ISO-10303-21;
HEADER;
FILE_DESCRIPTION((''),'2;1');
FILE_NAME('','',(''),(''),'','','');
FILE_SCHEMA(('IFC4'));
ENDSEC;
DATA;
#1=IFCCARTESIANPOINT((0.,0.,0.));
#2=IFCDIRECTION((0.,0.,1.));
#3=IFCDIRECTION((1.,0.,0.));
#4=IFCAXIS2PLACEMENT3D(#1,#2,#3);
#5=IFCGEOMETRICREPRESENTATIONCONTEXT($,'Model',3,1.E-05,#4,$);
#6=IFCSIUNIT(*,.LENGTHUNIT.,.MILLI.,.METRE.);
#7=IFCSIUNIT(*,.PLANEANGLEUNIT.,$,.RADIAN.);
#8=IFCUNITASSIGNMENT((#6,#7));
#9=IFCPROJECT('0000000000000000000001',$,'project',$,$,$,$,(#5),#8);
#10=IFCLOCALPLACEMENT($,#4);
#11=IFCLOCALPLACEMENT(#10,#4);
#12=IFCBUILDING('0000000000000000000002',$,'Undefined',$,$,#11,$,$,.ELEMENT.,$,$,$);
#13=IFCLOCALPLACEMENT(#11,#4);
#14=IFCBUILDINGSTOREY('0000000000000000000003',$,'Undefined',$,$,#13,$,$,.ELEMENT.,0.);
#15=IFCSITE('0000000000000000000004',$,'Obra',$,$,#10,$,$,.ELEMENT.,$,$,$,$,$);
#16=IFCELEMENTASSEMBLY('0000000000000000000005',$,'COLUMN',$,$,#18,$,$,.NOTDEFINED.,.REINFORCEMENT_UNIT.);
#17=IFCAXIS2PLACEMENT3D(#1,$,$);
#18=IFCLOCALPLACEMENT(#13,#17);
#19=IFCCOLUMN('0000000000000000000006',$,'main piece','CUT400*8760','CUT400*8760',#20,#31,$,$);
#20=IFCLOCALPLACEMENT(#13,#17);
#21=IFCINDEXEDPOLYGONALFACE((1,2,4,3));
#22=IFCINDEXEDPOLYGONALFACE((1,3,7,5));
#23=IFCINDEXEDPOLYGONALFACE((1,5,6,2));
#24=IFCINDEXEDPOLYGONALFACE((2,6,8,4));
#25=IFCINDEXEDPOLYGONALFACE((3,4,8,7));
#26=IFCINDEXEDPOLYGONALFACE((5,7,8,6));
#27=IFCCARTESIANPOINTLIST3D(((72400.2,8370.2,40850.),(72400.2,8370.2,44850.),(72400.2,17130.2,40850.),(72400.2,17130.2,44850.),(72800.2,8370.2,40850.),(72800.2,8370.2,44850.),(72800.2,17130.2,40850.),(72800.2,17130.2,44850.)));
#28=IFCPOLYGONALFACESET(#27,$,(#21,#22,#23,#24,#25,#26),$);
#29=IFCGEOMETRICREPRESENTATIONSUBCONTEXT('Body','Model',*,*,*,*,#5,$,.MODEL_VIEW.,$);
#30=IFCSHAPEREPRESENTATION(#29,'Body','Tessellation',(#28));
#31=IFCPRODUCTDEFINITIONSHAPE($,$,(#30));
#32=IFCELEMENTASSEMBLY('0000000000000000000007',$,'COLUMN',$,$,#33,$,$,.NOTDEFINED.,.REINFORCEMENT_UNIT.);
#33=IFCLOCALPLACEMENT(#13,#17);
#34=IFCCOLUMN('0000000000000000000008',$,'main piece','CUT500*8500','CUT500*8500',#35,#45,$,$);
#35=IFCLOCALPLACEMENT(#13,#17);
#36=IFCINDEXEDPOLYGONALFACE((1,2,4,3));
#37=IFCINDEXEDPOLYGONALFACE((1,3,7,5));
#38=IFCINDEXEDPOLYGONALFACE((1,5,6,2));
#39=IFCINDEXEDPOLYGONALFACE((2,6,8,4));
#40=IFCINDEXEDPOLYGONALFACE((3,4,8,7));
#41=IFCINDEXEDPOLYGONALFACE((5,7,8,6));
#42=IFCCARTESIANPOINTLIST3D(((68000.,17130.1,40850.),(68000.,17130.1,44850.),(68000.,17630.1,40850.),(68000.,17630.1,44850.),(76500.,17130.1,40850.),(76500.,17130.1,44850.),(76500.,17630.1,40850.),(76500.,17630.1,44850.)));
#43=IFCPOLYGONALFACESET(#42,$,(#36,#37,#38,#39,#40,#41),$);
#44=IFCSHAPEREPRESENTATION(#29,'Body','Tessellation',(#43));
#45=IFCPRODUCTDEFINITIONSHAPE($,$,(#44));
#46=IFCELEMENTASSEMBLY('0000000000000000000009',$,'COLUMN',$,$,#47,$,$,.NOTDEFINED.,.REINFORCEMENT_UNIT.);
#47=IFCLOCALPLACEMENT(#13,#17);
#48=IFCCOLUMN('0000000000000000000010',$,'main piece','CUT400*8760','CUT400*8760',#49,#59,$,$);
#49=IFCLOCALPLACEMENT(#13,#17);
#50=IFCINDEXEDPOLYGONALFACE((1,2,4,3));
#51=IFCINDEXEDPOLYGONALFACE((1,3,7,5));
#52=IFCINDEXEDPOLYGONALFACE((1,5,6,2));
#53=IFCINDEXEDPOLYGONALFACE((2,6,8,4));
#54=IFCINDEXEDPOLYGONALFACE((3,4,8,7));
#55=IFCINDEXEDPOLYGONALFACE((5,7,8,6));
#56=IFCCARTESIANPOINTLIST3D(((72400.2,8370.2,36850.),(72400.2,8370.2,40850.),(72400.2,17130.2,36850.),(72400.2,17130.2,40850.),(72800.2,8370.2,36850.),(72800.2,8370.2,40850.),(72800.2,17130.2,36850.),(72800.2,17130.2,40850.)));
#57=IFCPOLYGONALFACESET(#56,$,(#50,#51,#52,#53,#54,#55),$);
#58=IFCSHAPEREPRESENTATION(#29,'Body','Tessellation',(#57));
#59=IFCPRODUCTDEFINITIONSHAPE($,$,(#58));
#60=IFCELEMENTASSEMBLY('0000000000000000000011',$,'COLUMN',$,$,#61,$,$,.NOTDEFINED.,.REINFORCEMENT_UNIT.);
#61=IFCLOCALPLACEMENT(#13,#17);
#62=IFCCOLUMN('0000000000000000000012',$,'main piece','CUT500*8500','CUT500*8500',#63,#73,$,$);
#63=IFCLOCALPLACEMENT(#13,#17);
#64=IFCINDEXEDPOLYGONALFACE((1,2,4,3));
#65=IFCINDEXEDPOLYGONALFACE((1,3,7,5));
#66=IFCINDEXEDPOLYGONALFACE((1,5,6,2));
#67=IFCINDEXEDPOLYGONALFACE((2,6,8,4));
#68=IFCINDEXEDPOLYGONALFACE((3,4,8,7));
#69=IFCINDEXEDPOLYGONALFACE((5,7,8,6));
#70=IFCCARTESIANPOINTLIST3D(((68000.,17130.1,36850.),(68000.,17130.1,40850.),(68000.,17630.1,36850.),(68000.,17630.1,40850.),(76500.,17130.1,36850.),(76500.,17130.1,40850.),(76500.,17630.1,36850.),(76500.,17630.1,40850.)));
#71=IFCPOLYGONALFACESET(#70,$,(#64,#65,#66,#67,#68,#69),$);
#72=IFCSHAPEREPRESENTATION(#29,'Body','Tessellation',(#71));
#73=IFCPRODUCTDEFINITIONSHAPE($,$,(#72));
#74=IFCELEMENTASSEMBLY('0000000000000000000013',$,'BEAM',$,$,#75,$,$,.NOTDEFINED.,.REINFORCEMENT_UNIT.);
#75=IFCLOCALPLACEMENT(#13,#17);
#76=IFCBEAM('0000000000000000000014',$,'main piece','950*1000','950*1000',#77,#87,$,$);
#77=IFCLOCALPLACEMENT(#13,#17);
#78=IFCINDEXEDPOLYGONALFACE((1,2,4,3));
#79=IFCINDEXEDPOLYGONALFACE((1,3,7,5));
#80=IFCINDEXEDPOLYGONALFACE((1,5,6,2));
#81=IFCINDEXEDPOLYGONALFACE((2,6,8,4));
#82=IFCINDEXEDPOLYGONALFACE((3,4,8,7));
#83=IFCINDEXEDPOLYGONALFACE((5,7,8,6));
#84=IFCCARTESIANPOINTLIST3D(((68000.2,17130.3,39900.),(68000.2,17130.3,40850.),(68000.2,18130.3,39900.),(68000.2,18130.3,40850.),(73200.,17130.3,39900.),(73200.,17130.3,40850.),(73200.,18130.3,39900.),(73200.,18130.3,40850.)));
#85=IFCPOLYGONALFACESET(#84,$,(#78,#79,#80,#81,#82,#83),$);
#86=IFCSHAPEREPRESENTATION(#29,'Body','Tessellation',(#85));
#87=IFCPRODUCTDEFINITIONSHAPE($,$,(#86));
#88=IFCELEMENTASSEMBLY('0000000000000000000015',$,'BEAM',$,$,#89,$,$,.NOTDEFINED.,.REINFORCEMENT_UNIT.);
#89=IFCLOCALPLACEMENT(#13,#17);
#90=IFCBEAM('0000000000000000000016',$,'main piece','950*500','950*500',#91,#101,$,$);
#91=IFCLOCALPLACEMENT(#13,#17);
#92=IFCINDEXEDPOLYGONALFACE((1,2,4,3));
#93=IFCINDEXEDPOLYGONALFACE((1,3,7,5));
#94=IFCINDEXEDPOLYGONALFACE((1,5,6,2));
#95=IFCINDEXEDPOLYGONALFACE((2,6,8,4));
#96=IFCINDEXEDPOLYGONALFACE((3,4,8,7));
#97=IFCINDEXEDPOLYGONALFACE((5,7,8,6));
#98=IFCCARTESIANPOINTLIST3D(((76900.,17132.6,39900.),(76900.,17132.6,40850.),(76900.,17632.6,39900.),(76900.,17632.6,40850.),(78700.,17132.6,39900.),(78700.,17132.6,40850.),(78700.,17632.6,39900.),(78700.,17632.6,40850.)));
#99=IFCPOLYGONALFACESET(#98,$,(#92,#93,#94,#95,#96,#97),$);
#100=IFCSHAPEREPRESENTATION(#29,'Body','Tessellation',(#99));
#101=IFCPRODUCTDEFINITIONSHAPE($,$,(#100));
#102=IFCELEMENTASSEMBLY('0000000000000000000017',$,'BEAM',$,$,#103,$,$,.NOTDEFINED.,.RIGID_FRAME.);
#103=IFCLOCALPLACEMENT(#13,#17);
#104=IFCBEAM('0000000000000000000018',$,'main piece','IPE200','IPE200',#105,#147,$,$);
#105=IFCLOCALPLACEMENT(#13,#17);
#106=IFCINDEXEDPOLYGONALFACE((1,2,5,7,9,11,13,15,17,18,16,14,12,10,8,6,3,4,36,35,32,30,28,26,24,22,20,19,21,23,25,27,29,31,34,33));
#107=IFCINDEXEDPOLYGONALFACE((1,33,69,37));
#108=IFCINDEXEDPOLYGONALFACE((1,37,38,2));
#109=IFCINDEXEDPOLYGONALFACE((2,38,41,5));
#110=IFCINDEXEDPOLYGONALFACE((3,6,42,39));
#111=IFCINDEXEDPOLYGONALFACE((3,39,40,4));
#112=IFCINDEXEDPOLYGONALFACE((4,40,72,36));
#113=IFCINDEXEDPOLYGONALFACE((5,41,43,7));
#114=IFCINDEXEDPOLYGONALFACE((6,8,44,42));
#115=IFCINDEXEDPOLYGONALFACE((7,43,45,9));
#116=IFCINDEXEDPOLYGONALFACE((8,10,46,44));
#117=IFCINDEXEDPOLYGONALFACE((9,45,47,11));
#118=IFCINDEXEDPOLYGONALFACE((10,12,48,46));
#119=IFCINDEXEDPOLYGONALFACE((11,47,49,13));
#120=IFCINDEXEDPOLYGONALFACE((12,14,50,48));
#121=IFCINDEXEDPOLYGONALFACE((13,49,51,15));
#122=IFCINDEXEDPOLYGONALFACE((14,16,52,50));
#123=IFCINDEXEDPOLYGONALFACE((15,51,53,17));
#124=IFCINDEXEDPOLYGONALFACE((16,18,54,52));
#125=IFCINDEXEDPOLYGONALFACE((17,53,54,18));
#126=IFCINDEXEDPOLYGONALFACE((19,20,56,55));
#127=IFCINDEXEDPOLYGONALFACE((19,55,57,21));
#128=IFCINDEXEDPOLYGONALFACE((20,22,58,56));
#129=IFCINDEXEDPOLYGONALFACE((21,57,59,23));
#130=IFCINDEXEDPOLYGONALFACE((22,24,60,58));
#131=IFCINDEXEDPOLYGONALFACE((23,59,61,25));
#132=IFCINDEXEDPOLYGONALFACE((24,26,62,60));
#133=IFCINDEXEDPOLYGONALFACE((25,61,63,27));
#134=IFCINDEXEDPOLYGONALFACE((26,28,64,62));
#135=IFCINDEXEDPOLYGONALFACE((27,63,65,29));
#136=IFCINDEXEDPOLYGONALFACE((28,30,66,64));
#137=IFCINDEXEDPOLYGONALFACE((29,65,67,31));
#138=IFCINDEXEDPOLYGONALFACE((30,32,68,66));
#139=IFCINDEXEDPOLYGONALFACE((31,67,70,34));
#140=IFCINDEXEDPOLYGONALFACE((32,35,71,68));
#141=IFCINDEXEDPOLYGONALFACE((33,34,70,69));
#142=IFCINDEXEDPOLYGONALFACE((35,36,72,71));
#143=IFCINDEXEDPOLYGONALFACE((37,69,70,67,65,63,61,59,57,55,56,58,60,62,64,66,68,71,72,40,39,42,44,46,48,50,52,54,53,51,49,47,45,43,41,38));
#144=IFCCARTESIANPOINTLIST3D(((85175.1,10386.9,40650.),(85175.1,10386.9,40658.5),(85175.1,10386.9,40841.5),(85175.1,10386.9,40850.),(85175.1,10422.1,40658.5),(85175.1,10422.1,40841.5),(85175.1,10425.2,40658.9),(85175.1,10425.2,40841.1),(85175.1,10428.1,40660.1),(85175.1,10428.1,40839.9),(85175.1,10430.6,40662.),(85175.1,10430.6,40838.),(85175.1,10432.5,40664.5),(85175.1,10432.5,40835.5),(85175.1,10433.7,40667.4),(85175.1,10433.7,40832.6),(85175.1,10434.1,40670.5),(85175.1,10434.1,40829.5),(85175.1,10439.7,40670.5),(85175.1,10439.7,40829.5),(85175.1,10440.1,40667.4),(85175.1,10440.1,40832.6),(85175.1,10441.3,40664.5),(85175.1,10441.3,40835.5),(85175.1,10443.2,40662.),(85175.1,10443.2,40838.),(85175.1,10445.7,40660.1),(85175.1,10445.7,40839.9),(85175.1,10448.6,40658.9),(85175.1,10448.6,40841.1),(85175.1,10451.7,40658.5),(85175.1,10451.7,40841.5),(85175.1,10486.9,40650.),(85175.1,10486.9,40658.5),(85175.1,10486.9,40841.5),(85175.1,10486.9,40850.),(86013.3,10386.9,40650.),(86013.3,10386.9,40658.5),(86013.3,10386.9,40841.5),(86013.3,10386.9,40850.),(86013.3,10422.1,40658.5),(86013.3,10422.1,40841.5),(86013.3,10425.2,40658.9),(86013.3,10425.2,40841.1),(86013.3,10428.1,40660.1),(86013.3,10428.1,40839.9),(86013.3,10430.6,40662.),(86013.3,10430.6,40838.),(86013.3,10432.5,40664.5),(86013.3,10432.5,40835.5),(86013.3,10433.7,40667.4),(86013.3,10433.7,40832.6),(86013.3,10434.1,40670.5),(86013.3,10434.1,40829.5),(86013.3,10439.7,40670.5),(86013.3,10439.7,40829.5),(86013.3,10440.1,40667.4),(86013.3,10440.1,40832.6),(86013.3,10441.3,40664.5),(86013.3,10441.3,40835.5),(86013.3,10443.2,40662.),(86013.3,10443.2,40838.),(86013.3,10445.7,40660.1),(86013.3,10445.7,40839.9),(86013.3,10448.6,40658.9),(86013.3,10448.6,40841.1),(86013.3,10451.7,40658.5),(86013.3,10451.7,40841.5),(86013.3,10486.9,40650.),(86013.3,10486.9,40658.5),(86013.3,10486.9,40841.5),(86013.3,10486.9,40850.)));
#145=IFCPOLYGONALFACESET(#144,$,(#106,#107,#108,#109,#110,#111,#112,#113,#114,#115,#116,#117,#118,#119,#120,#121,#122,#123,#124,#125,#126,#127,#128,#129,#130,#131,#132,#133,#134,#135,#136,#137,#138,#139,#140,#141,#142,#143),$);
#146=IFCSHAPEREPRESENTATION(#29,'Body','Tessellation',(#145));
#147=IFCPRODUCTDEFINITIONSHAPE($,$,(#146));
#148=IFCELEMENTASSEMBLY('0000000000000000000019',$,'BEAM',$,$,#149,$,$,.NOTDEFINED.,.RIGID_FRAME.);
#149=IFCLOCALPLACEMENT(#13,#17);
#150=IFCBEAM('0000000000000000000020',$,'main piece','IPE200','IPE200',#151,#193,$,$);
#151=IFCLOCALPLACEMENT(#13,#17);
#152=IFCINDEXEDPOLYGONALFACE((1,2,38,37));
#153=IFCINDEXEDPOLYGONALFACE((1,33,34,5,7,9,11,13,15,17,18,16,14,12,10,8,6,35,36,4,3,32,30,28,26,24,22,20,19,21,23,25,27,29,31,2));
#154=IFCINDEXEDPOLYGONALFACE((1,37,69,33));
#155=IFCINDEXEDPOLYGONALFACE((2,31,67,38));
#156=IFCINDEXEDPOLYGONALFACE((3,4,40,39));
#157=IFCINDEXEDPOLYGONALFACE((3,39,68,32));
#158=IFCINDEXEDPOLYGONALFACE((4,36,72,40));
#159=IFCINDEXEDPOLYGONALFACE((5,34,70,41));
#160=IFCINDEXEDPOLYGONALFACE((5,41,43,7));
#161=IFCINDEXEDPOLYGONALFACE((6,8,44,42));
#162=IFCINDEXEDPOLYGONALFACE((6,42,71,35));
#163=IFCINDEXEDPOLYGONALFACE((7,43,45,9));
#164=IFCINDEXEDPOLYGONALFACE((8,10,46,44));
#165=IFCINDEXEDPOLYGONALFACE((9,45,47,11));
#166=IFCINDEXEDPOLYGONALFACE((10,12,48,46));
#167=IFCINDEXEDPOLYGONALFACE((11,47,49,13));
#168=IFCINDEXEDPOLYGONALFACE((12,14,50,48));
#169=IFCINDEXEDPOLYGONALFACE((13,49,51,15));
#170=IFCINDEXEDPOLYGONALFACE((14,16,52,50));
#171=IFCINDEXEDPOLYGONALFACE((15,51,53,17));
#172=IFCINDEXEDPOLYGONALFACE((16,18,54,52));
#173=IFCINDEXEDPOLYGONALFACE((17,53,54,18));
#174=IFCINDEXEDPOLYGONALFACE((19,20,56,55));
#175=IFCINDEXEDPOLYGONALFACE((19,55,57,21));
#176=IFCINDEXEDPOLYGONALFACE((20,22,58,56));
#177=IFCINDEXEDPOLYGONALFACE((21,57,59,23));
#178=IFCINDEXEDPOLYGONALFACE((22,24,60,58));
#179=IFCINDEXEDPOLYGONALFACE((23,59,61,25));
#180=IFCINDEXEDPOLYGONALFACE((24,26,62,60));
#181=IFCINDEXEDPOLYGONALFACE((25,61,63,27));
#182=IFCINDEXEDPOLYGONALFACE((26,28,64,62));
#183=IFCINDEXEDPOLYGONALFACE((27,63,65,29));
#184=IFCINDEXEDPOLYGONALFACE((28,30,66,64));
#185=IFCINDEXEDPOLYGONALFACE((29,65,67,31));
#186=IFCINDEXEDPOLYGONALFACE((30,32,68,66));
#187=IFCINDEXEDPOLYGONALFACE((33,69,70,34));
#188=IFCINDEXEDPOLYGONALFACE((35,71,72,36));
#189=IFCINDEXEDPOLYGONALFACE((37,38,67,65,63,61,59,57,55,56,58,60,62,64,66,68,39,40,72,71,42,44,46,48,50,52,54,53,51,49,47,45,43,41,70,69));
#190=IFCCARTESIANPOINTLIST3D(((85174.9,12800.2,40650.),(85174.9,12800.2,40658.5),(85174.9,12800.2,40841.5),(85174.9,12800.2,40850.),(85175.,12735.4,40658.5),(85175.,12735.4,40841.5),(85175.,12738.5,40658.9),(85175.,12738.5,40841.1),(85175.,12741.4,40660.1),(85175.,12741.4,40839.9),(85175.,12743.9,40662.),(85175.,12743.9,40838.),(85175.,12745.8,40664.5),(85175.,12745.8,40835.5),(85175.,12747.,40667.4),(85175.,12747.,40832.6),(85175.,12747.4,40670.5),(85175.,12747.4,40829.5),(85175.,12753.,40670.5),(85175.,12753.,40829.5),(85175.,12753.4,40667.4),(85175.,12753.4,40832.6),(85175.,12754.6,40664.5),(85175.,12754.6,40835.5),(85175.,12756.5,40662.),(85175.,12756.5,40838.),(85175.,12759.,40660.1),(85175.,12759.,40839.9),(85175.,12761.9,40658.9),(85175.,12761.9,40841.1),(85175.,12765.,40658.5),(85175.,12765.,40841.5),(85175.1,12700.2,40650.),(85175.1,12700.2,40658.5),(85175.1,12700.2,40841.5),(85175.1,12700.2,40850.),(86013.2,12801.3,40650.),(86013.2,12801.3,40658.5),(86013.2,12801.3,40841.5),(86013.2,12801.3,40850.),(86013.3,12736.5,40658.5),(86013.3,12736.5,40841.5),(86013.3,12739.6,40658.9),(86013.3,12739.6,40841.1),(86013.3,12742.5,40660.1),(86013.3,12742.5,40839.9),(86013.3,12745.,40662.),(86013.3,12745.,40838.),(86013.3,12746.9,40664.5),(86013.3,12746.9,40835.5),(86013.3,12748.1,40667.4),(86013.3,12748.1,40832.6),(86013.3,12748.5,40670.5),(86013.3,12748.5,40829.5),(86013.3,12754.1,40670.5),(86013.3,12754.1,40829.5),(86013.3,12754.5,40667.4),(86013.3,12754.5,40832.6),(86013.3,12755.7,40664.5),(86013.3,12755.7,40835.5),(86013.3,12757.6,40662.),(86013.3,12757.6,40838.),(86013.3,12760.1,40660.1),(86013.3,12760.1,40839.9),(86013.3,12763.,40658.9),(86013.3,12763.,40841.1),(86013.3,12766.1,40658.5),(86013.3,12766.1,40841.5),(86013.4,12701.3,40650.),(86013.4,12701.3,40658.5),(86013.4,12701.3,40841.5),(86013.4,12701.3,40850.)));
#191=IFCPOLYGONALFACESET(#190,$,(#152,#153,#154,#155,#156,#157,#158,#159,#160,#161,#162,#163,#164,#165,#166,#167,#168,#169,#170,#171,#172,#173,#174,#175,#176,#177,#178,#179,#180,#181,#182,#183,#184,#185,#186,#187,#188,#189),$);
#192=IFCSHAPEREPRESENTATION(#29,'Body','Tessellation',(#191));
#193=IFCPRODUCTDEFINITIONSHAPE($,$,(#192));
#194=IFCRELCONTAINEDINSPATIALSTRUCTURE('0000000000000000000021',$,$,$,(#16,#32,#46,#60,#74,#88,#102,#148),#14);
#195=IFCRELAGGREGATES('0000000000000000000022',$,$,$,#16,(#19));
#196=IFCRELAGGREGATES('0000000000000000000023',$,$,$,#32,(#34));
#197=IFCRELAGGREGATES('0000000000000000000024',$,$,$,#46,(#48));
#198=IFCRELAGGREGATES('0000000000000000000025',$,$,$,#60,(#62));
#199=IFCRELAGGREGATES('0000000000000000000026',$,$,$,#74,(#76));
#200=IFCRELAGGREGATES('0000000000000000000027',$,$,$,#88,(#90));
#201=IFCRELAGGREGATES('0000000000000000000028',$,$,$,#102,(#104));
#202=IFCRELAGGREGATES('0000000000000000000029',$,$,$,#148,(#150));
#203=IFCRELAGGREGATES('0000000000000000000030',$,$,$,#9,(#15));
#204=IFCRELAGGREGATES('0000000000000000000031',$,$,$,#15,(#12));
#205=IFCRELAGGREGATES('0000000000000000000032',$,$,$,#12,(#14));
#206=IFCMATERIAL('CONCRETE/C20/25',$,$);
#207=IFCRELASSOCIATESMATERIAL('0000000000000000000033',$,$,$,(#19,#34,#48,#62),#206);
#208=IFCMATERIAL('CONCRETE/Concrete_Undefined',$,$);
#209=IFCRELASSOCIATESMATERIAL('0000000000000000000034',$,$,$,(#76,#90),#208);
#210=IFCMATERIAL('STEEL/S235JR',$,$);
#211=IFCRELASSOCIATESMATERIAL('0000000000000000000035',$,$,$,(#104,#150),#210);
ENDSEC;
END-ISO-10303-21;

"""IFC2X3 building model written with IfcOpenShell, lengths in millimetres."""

from ifc_helpers import new_model, si_unit, frame, origin_with_axes, origin_2d_with_axis, place, context, subcontext, project, spatial, rectangle, i_section, extrude, material, element, aggregate, save


model = new_model("IFC2X3")

# Units and contexts
model_context = context("Model", 3, precision=1e-05, world=origin_with_axes())
body_context = subcontext(model_context, "Body", "Model", "MODEL_VIEW")
ifc_project = project(units=[si_unit("LENGTHUNIT", "METRE", prefix="MILLI"), si_unit("PLANEANGLEUNIT", "RADIAN")], contexts=[model_context])

# Site, building, storey
site_placement = place(None, origin_with_axes())
site = spatial("IfcSite", under=ifc_project, at=site_placement, Name="Obra", CompositionType="ELEMENT")
building_placement = place(site_placement, origin_with_axes())
building = spatial("IfcBuilding", under=site, at=building_placement, Name="Undefined", CompositionType="ELEMENT")
storey_placement = place(building_placement, origin_with_axes())
storey = spatial("IfcBuildingStorey", under=building, at=storey_placement, Name="Undefined", CompositionType="ELEMENT", Elevation=0.0)

# Element assemblies, columns
assembly_1_placement = place(storey_placement, origin_with_axes())
assembly_1 = element("IfcElementAssembly", 1, at=assembly_1_placement, inside=storey, Name="COLUMN", AssemblyPlace="NOTDEFINED", PredefinedType="REINFORCEMENT_UNIT")
ifc_material_1 = material(Name="CONCRETE/C20/25")
column_1_placement = place(assembly_1_placement, frame((72600.2, 12750.2, 40850.0), z_axis=(0.0, 0.0, 1.0), x_axis=(0.0, -1.0, 0.0)))
column_1 = element("IfcColumn", 2, at=column_1_placement, material=ifc_material_1, Name="main piece", Description="CUT400*8760", ObjectType="CUT400*8760", context=body_context, shape_type="SweptSolid", body=[
    extrude(rectangle(XDim=400.0, YDim=8760.0, at=origin_2d_with_axis()), frame((0.0, 0.0, 4000.0), z_axis=(0.0, 0.0, -1.0), x_axis=(0.0, 1.0, 0.0)), (0.0, 0.0, 1.0), 4000.0),
])
aggregate(assembly_1, [column_1])
assembly_2_placement = place(storey_placement, origin_with_axes())
assembly_2 = element("IfcElementAssembly", 3, at=assembly_2_placement, inside=storey, Name="COLUMN", AssemblyPlace="NOTDEFINED", PredefinedType="REINFORCEMENT_UNIT")
column_2_placement = place(assembly_2_placement, frame((72250.0, 17380.1, 40850.0), z_axis=(0.0, 0.0, 1.0), x_axis=(-1.0, 0.0, 0.0)))
column_2 = element("IfcColumn", 4, at=column_2_placement, material=ifc_material_1, Name="main piece", Description="CUT500*8500", ObjectType="CUT500*8500", context=body_context, shape_type="SweptSolid", body=[
    extrude(rectangle(XDim=500.0, YDim=8500.0, at=origin_2d_with_axis()), frame((0.0, 0.0, 4000.0), z_axis=(0.0, 0.0, -1.0), x_axis=(0.0, 1.0, 0.0)), (0.0, 0.0, 1.0), 4000.0),
])
aggregate(assembly_2, [column_2])
assembly_3_placement = place(storey_placement, origin_with_axes())
assembly_3 = element("IfcElementAssembly", 5, at=assembly_3_placement, inside=storey, Name="COLUMN", AssemblyPlace="NOTDEFINED", PredefinedType="REINFORCEMENT_UNIT")
column_3_placement = place(assembly_3_placement, frame((72600.2, 12750.2, 36850.0), z_axis=(0.0, 0.0, 1.0), x_axis=(0.0, -1.0, 0.0)))
column_3 = element("IfcColumn", 6, at=column_3_placement, material=ifc_material_1, Name="main piece", Description="CUT400*8760", ObjectType="CUT400*8760", context=body_context, shape_type="SweptSolid", body=[
    extrude(rectangle(XDim=400.0, YDim=8760.0, at=origin_2d_with_axis()), frame((0.0, 0.0, 4000.0), z_axis=(0.0, 0.0, -1.0), x_axis=(0.0, 1.0, 0.0)), (0.0, 0.0, 1.0), 4000.0),
])
aggregate(assembly_3, [column_3])
assembly_4_placement = place(storey_placement, origin_with_axes())
assembly_4 = element("IfcElementAssembly", 7, at=assembly_4_placement, inside=storey, Name="COLUMN", AssemblyPlace="NOTDEFINED", PredefinedType="REINFORCEMENT_UNIT")
column_4_placement = place(assembly_4_placement, frame((72250.0, 17380.1, 36850.0), z_axis=(0.0, 0.0, 1.0), x_axis=(-1.0, 0.0, 0.0)))
column_4 = element("IfcColumn", 8, at=column_4_placement, material=ifc_material_1, Name="main piece", Description="CUT500*8500", ObjectType="CUT500*8500", context=body_context, shape_type="SweptSolid", body=[
    extrude(rectangle(XDim=500.0, YDim=8500.0, at=origin_2d_with_axis()), frame((0.0, 0.0, 4000.0), z_axis=(0.0, 0.0, -1.0), x_axis=(0.0, 1.0, 0.0)), (0.0, 0.0, 1.0), 4000.0),
])
aggregate(assembly_4, [column_4])

# Element assemblies, beams
assembly_5_placement = place(storey_placement, origin_with_axes())
assembly_5 = element("IfcElementAssembly", 9, at=assembly_5_placement, inside=storey, Name="BEAM", AssemblyPlace="NOTDEFINED", PredefinedType="REINFORCEMENT_UNIT")
ifc_material_2 = material(Name="CONCRETE/Concrete_Undefined")
beam_1_placement = place(assembly_5_placement, frame((68000.2, 17630.3, 40375.0), z_axis=(0.0, 0.0, 1.0), x_axis=(1.0, 0.0, 0.0)))
beam_1 = element("IfcBeam", 10, at=beam_1_placement, material=ifc_material_2, Name="main piece", Description="950*1000", ObjectType="950*1000", context=body_context, shape_type="SweptSolid", body=[
    extrude(rectangle(XDim=1000.0, YDim=950.0, at=origin_2d_with_axis()), frame((5199.8, 0.0, 0.0), z_axis=(-1.0, 0.0, 0.0), x_axis=(0.0, -1.0, 0.0)), (0.0, 0.0, 1.0), 5199.8),
])
aggregate(assembly_5, [beam_1])
assembly_6_placement = place(storey_placement, origin_with_axes())
assembly_6 = element("IfcElementAssembly", 11, at=assembly_6_placement, inside=storey, Name="BEAM", AssemblyPlace="NOTDEFINED", PredefinedType="REINFORCEMENT_UNIT")
beam_2_placement = place(assembly_6_placement, frame((78700.0, 17382.6, 40375.0), z_axis=(0.0, 0.0, 1.0), x_axis=(-1.0, 0.0, 0.0)))
beam_2 = element("IfcBeam", 12, at=beam_2_placement, material=ifc_material_2, Name="main piece", Description="950*500", ObjectType="950*500", context=body_context, shape_type="SweptSolid", body=[
    extrude(rectangle(XDim=500.0, YDim=950.0, at=origin_2d_with_axis()), frame((1800.0, 0.0, 0.0), z_axis=(-1.0, 0.0, 0.0), x_axis=(0.0, -1.0, 0.0)), (0.0, 0.0, 1.0), 1800.0),
])
aggregate(assembly_6, [beam_2])
assembly_7_placement = place(storey_placement, origin_with_axes())
assembly_7 = element("IfcElementAssembly", 13, at=assembly_7_placement, inside=storey, Name="BEAM", AssemblyPlace="NOTDEFINED", PredefinedType="RIGID_FRAME")
ifc_material_3 = material(Name="STEEL/S235JR")
beam_3_placement = place(assembly_7_placement, frame((85175.1, 10436.9, 40750.0), z_axis=(0.0, 0.0, 1.0), x_axis=(1.0, 0.0, 0.0)))
beam_3 = element("IfcBeam", 14, at=beam_3_placement, material=ifc_material_3, Name="main piece", Description="IPE200", ObjectType="IPE200", context=body_context, shape_type="SweptSolid", body=[
    extrude(i_section(OverallWidth=100.0, OverallDepth=200.0, WebThickness=5.6, FlangeThickness=8.5, FilletRadius=12.0, at=origin_2d_with_axis()), frame((838.2, 0.0, 0.0), z_axis=(-1.0, 0.0, 0.0), x_axis=(0.0, -1.0, 0.0)), (0.0, 0.0, 1.0), 838.2),
])
aggregate(assembly_7, [beam_3])
assembly_8_placement = place(storey_placement, origin_with_axes())
assembly_8 = element("IfcElementAssembly", 15, at=assembly_8_placement, inside=storey, Name="BEAM", AssemblyPlace="NOTDEFINED", PredefinedType="RIGID_FRAME")
beam_4_placement = place(assembly_8_placement, frame((85175.0, 12750.2, 40750.0), z_axis=(0.0, 0.0, 1.0), x_axis=(0.999999, 0.001338, 0.0)))
beam_4 = element("IfcBeam", 16, at=beam_4_placement, material=ifc_material_3, Name="main piece", Description="IPE200", ObjectType="IPE200", context=body_context, shape_type="SweptSolid", body=[
    extrude(i_section(OverallWidth=100.0, OverallDepth=200.0, WebThickness=5.6, FlangeThickness=8.5, FilletRadius=12.0, at=origin_2d_with_axis()), frame((838.3, 0.0, 0.0), z_axis=(-1.0, 0.0, 0.0), x_axis=(0.0, -1.0, 0.0)), (0.0, 0.0, 1.0), 838.3),
])
aggregate(assembly_8, [beam_4])

save(model, "model.ifc")
